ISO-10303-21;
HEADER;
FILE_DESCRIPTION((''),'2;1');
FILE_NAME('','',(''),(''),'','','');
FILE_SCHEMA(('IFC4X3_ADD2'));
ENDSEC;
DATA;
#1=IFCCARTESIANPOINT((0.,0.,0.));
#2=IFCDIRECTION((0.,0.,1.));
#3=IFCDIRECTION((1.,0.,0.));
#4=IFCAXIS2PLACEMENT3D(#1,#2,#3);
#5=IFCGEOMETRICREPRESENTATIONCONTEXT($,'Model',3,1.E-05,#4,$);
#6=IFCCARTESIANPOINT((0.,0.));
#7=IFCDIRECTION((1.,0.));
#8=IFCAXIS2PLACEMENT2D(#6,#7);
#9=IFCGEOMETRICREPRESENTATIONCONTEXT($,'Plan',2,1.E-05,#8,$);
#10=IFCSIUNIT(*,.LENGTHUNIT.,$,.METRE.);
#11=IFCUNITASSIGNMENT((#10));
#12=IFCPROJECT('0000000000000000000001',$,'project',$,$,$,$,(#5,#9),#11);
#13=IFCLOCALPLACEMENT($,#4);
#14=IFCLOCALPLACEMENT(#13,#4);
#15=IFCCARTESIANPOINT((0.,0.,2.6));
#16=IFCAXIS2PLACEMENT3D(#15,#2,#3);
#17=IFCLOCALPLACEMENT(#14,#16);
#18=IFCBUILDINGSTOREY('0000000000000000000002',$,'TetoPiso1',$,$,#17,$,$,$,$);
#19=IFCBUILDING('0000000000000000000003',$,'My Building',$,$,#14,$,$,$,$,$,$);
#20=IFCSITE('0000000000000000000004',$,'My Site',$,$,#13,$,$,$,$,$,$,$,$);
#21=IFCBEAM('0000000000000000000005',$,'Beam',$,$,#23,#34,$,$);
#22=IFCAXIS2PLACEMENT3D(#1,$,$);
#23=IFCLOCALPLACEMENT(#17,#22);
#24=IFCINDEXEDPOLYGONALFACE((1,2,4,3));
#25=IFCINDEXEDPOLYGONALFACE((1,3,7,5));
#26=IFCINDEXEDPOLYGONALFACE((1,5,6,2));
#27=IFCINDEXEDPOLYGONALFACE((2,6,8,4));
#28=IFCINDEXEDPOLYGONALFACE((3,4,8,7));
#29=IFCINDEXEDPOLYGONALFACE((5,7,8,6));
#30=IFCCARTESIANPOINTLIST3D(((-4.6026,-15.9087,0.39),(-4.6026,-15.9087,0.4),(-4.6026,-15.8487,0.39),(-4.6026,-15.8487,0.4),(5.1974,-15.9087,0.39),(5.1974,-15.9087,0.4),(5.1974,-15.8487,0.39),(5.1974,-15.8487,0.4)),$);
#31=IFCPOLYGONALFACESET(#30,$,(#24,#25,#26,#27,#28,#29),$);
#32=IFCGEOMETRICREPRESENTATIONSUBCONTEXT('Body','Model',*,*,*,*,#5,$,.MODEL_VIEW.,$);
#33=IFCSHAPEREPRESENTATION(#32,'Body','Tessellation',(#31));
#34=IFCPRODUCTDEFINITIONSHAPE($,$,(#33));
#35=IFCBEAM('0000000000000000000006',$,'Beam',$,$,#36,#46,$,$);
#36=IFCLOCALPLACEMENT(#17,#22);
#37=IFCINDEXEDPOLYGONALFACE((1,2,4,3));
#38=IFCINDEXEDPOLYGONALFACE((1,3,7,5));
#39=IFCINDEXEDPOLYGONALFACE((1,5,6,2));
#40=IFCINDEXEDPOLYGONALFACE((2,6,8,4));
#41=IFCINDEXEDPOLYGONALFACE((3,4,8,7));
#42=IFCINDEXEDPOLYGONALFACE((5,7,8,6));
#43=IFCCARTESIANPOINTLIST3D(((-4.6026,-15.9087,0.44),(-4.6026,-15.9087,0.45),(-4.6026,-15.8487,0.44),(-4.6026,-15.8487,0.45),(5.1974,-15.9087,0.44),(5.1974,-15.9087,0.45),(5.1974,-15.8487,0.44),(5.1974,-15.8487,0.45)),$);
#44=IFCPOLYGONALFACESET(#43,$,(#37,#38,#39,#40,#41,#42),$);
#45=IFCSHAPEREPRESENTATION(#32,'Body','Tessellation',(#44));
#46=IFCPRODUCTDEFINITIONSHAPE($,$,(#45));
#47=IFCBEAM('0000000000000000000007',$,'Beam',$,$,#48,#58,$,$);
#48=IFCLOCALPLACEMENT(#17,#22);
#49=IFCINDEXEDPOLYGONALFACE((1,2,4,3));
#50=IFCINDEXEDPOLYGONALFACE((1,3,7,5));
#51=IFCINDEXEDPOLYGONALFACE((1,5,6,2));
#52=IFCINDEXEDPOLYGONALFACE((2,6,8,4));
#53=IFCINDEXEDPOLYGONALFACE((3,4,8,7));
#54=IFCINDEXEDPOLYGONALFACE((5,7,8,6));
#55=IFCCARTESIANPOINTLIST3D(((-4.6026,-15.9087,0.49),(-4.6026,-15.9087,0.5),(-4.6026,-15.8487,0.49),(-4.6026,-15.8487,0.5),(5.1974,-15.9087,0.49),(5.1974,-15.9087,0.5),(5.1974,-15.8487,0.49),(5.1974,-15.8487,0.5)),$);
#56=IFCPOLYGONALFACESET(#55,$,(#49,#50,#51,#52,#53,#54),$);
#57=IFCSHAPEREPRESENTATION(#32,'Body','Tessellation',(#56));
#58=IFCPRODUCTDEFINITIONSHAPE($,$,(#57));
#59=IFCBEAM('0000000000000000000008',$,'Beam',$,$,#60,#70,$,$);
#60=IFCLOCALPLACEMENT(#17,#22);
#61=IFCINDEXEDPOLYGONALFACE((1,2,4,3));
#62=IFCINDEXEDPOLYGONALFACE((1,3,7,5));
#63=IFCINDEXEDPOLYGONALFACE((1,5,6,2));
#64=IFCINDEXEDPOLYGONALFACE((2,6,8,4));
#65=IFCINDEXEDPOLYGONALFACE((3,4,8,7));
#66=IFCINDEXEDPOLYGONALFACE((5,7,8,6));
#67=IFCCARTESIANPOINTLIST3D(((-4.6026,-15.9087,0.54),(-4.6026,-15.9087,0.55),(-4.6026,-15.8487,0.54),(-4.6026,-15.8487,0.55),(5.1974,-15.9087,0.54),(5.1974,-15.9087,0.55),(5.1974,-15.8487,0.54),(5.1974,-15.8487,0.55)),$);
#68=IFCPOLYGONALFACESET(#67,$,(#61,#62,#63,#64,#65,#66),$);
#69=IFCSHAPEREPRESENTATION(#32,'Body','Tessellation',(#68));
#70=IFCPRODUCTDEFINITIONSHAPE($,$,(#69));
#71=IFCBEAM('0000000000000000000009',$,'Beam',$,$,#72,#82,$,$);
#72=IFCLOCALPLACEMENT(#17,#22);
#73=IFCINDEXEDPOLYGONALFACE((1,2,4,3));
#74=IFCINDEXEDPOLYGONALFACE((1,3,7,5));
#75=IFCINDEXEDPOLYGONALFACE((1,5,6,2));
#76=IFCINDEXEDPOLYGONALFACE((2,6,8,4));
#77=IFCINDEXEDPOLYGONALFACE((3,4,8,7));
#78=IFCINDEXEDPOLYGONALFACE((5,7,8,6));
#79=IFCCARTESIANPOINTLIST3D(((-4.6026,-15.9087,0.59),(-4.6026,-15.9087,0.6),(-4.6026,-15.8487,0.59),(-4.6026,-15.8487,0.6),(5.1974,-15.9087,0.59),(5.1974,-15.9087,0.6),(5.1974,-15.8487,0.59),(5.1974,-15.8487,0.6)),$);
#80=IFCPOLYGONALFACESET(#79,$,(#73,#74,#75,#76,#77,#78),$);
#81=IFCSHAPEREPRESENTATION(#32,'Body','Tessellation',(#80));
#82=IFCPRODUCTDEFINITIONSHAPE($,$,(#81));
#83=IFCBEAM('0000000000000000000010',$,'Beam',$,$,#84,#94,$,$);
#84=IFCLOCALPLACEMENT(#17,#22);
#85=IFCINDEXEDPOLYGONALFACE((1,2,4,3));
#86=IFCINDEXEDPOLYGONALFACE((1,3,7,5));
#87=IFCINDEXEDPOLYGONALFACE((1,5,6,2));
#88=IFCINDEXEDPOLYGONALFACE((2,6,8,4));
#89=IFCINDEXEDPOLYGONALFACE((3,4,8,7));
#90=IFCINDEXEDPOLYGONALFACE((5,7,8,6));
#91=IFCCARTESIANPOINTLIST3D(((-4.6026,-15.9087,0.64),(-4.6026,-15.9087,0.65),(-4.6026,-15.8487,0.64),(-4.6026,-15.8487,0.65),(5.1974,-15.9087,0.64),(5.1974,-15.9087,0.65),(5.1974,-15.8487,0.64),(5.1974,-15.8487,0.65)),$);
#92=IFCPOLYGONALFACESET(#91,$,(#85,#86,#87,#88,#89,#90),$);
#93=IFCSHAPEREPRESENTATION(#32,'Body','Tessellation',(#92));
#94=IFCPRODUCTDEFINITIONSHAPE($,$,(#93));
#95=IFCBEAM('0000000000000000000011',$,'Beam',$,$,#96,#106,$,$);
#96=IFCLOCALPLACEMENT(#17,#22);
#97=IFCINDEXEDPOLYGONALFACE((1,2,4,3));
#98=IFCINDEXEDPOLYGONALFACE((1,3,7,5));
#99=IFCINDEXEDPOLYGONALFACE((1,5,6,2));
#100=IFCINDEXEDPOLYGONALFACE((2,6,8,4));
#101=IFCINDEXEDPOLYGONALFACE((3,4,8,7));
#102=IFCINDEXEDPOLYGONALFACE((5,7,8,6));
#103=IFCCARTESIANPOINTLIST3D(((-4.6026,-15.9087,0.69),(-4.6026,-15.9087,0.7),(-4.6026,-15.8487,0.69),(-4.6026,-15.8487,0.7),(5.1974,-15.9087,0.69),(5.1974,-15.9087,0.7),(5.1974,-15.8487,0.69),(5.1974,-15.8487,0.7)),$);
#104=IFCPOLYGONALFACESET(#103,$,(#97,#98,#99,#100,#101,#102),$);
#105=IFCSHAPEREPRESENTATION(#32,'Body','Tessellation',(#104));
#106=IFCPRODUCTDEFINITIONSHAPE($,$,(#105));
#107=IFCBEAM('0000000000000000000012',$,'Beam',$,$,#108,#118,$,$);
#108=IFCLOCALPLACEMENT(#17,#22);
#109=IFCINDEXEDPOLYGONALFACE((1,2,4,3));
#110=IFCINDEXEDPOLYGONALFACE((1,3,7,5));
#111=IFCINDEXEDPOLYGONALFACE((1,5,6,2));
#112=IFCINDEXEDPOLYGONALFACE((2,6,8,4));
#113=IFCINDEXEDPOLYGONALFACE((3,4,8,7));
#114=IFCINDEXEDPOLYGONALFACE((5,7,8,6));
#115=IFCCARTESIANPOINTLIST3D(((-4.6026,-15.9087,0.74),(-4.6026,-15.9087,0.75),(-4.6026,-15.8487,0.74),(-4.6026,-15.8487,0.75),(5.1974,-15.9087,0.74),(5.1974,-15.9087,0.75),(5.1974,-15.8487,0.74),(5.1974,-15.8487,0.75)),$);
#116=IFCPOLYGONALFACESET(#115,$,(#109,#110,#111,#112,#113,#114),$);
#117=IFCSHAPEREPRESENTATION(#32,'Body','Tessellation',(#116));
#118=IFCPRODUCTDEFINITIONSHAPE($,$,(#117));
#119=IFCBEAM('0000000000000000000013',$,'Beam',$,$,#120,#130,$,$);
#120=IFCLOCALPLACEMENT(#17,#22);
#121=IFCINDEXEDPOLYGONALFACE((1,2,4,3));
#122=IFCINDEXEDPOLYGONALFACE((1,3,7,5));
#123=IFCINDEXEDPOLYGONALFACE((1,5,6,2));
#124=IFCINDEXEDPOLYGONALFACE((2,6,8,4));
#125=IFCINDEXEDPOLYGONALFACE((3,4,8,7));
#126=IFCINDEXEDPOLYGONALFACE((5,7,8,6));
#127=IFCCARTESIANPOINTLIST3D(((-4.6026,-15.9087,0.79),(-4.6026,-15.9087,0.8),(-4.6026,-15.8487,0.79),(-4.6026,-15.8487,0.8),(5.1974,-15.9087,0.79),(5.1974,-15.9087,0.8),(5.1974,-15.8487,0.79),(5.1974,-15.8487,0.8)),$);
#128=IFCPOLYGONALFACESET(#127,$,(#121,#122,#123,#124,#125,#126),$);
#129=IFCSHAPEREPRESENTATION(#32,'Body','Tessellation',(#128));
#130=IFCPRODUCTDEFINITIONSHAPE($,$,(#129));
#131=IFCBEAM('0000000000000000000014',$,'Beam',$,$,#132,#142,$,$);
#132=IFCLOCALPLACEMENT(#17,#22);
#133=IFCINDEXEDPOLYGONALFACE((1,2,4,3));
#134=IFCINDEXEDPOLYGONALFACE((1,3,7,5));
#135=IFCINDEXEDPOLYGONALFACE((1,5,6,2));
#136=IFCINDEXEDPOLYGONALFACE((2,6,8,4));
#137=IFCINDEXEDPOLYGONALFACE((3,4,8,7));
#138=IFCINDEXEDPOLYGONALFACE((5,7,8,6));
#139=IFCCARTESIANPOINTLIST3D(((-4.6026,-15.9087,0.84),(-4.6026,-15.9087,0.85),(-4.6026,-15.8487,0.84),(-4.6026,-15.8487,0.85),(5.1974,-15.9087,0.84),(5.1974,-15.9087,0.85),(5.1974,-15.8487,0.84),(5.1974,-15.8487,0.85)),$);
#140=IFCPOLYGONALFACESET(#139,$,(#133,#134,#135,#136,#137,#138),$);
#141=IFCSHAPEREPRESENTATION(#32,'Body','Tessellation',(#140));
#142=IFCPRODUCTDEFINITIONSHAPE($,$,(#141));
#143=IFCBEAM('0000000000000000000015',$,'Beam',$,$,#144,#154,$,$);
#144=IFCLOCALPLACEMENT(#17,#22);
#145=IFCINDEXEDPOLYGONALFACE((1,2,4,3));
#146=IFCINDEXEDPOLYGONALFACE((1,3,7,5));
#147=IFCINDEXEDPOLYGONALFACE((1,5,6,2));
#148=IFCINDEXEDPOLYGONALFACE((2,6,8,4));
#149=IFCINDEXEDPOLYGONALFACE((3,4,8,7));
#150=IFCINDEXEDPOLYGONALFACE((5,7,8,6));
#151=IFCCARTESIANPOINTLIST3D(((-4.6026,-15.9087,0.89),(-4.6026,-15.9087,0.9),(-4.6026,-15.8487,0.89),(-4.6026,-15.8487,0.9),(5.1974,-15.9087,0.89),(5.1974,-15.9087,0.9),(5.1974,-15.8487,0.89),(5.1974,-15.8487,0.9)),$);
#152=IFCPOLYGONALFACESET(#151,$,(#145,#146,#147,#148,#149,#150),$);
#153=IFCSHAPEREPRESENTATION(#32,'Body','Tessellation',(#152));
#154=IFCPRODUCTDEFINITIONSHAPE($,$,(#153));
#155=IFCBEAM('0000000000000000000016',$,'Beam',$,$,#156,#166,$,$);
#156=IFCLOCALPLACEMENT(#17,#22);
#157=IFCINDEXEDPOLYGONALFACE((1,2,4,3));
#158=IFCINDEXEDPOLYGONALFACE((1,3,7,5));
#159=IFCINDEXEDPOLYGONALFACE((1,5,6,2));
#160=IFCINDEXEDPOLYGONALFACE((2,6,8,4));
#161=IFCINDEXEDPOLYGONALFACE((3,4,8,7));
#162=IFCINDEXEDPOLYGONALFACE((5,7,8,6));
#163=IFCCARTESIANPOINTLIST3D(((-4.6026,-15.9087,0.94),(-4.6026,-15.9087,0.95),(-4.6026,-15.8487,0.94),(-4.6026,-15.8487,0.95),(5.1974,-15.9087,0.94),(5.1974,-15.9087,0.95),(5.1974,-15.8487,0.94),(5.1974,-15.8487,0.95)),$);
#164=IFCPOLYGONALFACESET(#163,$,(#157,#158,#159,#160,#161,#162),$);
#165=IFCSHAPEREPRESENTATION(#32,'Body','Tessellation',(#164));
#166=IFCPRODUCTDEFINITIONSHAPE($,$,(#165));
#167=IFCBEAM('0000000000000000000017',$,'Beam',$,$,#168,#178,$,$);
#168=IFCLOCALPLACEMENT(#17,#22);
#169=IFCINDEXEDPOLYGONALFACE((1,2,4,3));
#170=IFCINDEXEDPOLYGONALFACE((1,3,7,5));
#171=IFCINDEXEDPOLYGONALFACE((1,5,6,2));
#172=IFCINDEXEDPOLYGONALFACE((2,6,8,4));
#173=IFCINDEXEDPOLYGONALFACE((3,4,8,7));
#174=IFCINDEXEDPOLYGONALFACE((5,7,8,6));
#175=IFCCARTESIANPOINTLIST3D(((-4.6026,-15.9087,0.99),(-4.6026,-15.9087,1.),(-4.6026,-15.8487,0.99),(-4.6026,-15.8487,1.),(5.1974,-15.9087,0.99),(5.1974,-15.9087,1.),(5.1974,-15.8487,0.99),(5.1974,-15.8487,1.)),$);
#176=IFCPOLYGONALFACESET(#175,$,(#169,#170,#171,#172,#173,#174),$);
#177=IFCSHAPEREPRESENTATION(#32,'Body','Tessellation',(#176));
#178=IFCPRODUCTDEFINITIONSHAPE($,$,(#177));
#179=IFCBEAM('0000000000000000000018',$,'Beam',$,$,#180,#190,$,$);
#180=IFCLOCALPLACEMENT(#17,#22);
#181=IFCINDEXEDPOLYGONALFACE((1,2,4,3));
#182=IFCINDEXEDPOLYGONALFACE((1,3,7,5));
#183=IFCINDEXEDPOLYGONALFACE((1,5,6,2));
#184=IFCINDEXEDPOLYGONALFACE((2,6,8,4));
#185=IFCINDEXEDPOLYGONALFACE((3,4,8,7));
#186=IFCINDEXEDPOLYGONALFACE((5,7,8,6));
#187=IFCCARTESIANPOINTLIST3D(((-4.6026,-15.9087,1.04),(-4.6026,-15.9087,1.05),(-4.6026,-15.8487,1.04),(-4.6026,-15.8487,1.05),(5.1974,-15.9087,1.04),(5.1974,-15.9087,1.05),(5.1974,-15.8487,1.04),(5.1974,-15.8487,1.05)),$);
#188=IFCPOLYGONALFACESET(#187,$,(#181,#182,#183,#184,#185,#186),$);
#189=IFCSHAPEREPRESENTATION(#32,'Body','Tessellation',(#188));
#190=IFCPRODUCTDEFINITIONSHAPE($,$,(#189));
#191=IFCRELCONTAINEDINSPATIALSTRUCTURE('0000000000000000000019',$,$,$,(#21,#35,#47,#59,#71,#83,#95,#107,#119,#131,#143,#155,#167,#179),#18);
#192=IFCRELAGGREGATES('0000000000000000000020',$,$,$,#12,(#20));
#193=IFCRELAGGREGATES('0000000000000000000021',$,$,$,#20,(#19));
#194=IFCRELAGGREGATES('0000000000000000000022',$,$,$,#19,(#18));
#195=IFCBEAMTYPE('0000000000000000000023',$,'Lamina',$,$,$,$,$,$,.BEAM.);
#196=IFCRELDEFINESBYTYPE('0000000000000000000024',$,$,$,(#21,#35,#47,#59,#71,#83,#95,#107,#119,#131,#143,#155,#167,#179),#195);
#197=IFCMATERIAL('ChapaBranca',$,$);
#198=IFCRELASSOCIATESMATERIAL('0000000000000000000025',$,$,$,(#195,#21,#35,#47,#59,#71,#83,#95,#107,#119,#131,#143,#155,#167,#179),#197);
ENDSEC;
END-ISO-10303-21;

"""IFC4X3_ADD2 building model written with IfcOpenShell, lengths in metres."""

from ifc_helpers import new_model, si_unit, frame, origin_with_axes, origin_2d, origin_2d_with_axis, place, context, subcontext, project, spatial, rectangle, extrude, material, material_profile, profile_set, profile_usage, type_object, element, save


model = new_model("IFC4X3_ADD2")

# Units and contexts
model_context = context("Model", 3, precision=1e-05, world=origin_with_axes())
plan_context = context("Plan", 2, precision=1e-05, world=origin_2d_with_axis())
body_context = subcontext(model_context, "Body", "Model", "MODEL_VIEW")
ifc_project = project(units=[si_unit("LENGTHUNIT", "METRE")], contexts=[model_context, plan_context])

# Site, building, storey
site_placement = place(None, origin_with_axes())
site = spatial("IfcSite", under=ifc_project, at=site_placement, Name="My Site")
building_placement = place(site_placement, origin_with_axes())
building = spatial("IfcBuilding", under=site, at=building_placement, Name="My Building")
storey_placement = place(building_placement, frame((0.0, 0.0, 2.6), z_axis=(0.0, 0.0, 1.0), x_axis=(1.0, 0.0, 0.0)))
storey = spatial("IfcBuildingStorey", under=building, at=storey_placement, Name="TetoPiso1")

# Beams
ifc_material_1 = material(Name="ChapaBranca")
ifc_material_profile_1 = material_profile(ifc_material_1, rectangle(XDim=0.06, YDim=0.01, at=origin_2d()))
ifc_profile_set_1 = profile_set([ifc_material_profile_1])
beam_type_1 = type_object("IfcBeamType", Name="Lamina", PredefinedType="BEAM", material=ifc_profile_set_1)
ifc_profile_usage_1 = profile_usage(ifc_profile_set_1, cardinal=5)
beam_1_placement = place(storey_placement, frame((-4.6026, -15.8787, 0.395), z_axis=(1.0, 0.0, 0.0), x_axis=(0.0, 1.0, 0.0)))
element("IfcBeam", 1, at=beam_1_placement, inside=storey, type_object=beam_type_1, material=ifc_profile_usage_1, Name="Beam", context=body_context, shape_type="SweptSolid", body=[
    extrude(rectangle(XDim=0.06, YDim=0.01, at=origin_2d()), origin_with_axes(), (0.0, 0.0, 1.0), 9.8),
])
ifc_profile_usage_2 = profile_usage(ifc_profile_set_1, cardinal=5)
beam_2_placement = place(storey_placement, frame((-4.6026, -15.8787, 0.445), z_axis=(1.0, 0.0, 0.0), x_axis=(0.0, 1.0, 0.0)))
element("IfcBeam", 2, at=beam_2_placement, inside=storey, type_object=beam_type_1, material=ifc_profile_usage_2, Name="Beam", context=body_context, shape_type="SweptSolid", body=[
    extrude(rectangle(XDim=0.06, YDim=0.01, at=origin_2d()), origin_with_axes(), (0.0, 0.0, 1.0), 9.8),
])
ifc_profile_usage_3 = profile_usage(ifc_profile_set_1, cardinal=5)
beam_3_placement = place(storey_placement, frame((-4.6026, -15.8787, 0.495), z_axis=(1.0, 0.0, 0.0), x_axis=(0.0, 1.0, 0.0)))
element("IfcBeam", 3, at=beam_3_placement, inside=storey, type_object=beam_type_1, material=ifc_profile_usage_3, Name="Beam", context=body_context, shape_type="SweptSolid", body=[
    extrude(rectangle(XDim=0.06, YDim=0.01, at=origin_2d()), origin_with_axes(), (0.0, 0.0, 1.0), 9.8),
])
ifc_profile_usage_4 = profile_usage(ifc_profile_set_1, cardinal=5)
beam_4_placement = place(storey_placement, frame((-4.6026, -15.8787, 0.545), z_axis=(1.0, 0.0, 0.0), x_axis=(0.0, 1.0, 0.0)))
element("IfcBeam", 4, at=beam_4_placement, inside=storey, type_object=beam_type_1, material=ifc_profile_usage_4, Name="Beam", context=body_context, shape_type="SweptSolid", body=[
    extrude(rectangle(XDim=0.06, YDim=0.01, at=origin_2d()), origin_with_axes(), (0.0, 0.0, 1.0), 9.8),
])
ifc_profile_usage_5 = profile_usage(ifc_profile_set_1, cardinal=5)
beam_5_placement = place(storey_placement, frame((-4.6026, -15.8787, 0.595), z_axis=(1.0, 0.0, 0.0), x_axis=(0.0, 1.0, 0.0)))
element("IfcBeam", 5, at=beam_5_placement, inside=storey, type_object=beam_type_1, material=ifc_profile_usage_5, Name="Beam", context=body_context, shape_type="SweptSolid", body=[
    extrude(rectangle(XDim=0.06, YDim=0.01, at=origin_2d()), origin_with_axes(), (0.0, 0.0, 1.0), 9.8),
])
ifc_profile_usage_6 = profile_usage(ifc_profile_set_1, cardinal=5)
beam_6_placement = place(storey_placement, frame((-4.6026, -15.8787, 0.645), z_axis=(1.0, 0.0, 0.0), x_axis=(0.0, 1.0, 0.0)))
element("IfcBeam", 6, at=beam_6_placement, inside=storey, type_object=beam_type_1, material=ifc_profile_usage_6, Name="Beam", context=body_context, shape_type="SweptSolid", body=[
    extrude(rectangle(XDim=0.06, YDim=0.01, at=origin_2d()), origin_with_axes(), (0.0, 0.0, 1.0), 9.8),
])
ifc_profile_usage_7 = profile_usage(ifc_profile_set_1, cardinal=5)
beam_7_placement = place(storey_placement, frame((-4.6026, -15.8787, 0.695), z_axis=(1.0, 0.0, 0.0), x_axis=(0.0, 1.0, 0.0)))
element("IfcBeam", 7, at=beam_7_placement, inside=storey, type_object=beam_type_1, material=ifc_profile_usage_7, Name="Beam", context=body_context, shape_type="SweptSolid", body=[
    extrude(rectangle(XDim=0.06, YDim=0.01, at=origin_2d()), origin_with_axes(), (0.0, 0.0, 1.0), 9.8),
])
ifc_profile_usage_8 = profile_usage(ifc_profile_set_1, cardinal=5)
beam_8_placement = place(storey_placement, frame((-4.6026, -15.8787, 0.745), z_axis=(1.0, 0.0, 0.0), x_axis=(0.0, 1.0, 0.0)))
element("IfcBeam", 8, at=beam_8_placement, inside=storey, type_object=beam_type_1, material=ifc_profile_usage_8, Name="Beam", context=body_context, shape_type="SweptSolid", body=[
    extrude(rectangle(XDim=0.06, YDim=0.01, at=origin_2d()), origin_with_axes(), (0.0, 0.0, 1.0), 9.8),
])
ifc_profile_usage_9 = profile_usage(ifc_profile_set_1, cardinal=5)
beam_9_placement = place(storey_placement, frame((-4.6026, -15.8787, 0.795), z_axis=(1.0, 0.0, 0.0), x_axis=(0.0, 1.0, 0.0)))
element("IfcBeam", 9, at=beam_9_placement, inside=storey, type_object=beam_type_1, material=ifc_profile_usage_9, Name="Beam", context=body_context, shape_type="SweptSolid", body=[
    extrude(rectangle(XDim=0.06, YDim=0.01, at=origin_2d()), origin_with_axes(), (0.0, 0.0, 1.0), 9.8),
])
ifc_profile_usage_10 = profile_usage(ifc_profile_set_1, cardinal=5)
beam_10_placement = place(storey_placement, frame((-4.6026, -15.8787, 0.845), z_axis=(1.0, 0.0, 0.0), x_axis=(0.0, 1.0, 0.0)))
element("IfcBeam", 10, at=beam_10_placement, inside=storey, type_object=beam_type_1, material=ifc_profile_usage_10, Name="Beam", context=body_context, shape_type="SweptSolid", body=[
    extrude(rectangle(XDim=0.06, YDim=0.01, at=origin_2d()), origin_with_axes(), (0.0, 0.0, 1.0), 9.8),
])
ifc_profile_usage_11 = profile_usage(ifc_profile_set_1, cardinal=5)
beam_11_placement = place(storey_placement, frame((-4.6026, -15.8787, 0.895), z_axis=(1.0, 0.0, 0.0), x_axis=(0.0, 1.0, 0.0)))
element("IfcBeam", 11, at=beam_11_placement, inside=storey, type_object=beam_type_1, material=ifc_profile_usage_11, Name="Beam", context=body_context, shape_type="SweptSolid", body=[
    extrude(rectangle(XDim=0.06, YDim=0.01, at=origin_2d()), origin_with_axes(), (0.0, 0.0, 1.0), 9.8),
])
ifc_profile_usage_12 = profile_usage(ifc_profile_set_1, cardinal=5)
beam_12_placement = place(storey_placement, frame((-4.6026, -15.8787, 0.945), z_axis=(1.0, 0.0, 0.0), x_axis=(0.0, 1.0, 0.0)))
element("IfcBeam", 12, at=beam_12_placement, inside=storey, type_object=beam_type_1, material=ifc_profile_usage_12, Name="Beam", context=body_context, shape_type="SweptSolid", body=[
    extrude(rectangle(XDim=0.06, YDim=0.01, at=origin_2d()), origin_with_axes(), (0.0, 0.0, 1.0), 9.8),
])
ifc_profile_usage_13 = profile_usage(ifc_profile_set_1, cardinal=5)
beam_13_placement = place(storey_placement, frame((-4.6026, -15.8787, 0.995), z_axis=(1.0, 0.0, 0.0), x_axis=(0.0, 1.0, 0.0)))
element("IfcBeam", 13, at=beam_13_placement, inside=storey, type_object=beam_type_1, material=ifc_profile_usage_13, Name="Beam", context=body_context, shape_type="SweptSolid", body=[
    extrude(rectangle(XDim=0.06, YDim=0.01, at=origin_2d()), origin_with_axes(), (0.0, 0.0, 1.0), 9.8),
])
ifc_profile_usage_14 = profile_usage(ifc_profile_set_1, cardinal=5)
beam_14_placement = place(storey_placement, frame((-4.6026, -15.8787, 1.045), z_axis=(1.0, 0.0, 0.0), x_axis=(0.0, 1.0, 0.0)))
element("IfcBeam", 14, at=beam_14_placement, inside=storey, type_object=beam_type_1, material=ifc_profile_usage_14, Name="Beam", context=body_context, shape_type="SweptSolid", body=[
    extrude(rectangle(XDim=0.06, YDim=0.01, at=origin_2d()), origin_with_axes(), (0.0, 0.0, 1.0), 9.8),
])

save(model, "model.ifc")
